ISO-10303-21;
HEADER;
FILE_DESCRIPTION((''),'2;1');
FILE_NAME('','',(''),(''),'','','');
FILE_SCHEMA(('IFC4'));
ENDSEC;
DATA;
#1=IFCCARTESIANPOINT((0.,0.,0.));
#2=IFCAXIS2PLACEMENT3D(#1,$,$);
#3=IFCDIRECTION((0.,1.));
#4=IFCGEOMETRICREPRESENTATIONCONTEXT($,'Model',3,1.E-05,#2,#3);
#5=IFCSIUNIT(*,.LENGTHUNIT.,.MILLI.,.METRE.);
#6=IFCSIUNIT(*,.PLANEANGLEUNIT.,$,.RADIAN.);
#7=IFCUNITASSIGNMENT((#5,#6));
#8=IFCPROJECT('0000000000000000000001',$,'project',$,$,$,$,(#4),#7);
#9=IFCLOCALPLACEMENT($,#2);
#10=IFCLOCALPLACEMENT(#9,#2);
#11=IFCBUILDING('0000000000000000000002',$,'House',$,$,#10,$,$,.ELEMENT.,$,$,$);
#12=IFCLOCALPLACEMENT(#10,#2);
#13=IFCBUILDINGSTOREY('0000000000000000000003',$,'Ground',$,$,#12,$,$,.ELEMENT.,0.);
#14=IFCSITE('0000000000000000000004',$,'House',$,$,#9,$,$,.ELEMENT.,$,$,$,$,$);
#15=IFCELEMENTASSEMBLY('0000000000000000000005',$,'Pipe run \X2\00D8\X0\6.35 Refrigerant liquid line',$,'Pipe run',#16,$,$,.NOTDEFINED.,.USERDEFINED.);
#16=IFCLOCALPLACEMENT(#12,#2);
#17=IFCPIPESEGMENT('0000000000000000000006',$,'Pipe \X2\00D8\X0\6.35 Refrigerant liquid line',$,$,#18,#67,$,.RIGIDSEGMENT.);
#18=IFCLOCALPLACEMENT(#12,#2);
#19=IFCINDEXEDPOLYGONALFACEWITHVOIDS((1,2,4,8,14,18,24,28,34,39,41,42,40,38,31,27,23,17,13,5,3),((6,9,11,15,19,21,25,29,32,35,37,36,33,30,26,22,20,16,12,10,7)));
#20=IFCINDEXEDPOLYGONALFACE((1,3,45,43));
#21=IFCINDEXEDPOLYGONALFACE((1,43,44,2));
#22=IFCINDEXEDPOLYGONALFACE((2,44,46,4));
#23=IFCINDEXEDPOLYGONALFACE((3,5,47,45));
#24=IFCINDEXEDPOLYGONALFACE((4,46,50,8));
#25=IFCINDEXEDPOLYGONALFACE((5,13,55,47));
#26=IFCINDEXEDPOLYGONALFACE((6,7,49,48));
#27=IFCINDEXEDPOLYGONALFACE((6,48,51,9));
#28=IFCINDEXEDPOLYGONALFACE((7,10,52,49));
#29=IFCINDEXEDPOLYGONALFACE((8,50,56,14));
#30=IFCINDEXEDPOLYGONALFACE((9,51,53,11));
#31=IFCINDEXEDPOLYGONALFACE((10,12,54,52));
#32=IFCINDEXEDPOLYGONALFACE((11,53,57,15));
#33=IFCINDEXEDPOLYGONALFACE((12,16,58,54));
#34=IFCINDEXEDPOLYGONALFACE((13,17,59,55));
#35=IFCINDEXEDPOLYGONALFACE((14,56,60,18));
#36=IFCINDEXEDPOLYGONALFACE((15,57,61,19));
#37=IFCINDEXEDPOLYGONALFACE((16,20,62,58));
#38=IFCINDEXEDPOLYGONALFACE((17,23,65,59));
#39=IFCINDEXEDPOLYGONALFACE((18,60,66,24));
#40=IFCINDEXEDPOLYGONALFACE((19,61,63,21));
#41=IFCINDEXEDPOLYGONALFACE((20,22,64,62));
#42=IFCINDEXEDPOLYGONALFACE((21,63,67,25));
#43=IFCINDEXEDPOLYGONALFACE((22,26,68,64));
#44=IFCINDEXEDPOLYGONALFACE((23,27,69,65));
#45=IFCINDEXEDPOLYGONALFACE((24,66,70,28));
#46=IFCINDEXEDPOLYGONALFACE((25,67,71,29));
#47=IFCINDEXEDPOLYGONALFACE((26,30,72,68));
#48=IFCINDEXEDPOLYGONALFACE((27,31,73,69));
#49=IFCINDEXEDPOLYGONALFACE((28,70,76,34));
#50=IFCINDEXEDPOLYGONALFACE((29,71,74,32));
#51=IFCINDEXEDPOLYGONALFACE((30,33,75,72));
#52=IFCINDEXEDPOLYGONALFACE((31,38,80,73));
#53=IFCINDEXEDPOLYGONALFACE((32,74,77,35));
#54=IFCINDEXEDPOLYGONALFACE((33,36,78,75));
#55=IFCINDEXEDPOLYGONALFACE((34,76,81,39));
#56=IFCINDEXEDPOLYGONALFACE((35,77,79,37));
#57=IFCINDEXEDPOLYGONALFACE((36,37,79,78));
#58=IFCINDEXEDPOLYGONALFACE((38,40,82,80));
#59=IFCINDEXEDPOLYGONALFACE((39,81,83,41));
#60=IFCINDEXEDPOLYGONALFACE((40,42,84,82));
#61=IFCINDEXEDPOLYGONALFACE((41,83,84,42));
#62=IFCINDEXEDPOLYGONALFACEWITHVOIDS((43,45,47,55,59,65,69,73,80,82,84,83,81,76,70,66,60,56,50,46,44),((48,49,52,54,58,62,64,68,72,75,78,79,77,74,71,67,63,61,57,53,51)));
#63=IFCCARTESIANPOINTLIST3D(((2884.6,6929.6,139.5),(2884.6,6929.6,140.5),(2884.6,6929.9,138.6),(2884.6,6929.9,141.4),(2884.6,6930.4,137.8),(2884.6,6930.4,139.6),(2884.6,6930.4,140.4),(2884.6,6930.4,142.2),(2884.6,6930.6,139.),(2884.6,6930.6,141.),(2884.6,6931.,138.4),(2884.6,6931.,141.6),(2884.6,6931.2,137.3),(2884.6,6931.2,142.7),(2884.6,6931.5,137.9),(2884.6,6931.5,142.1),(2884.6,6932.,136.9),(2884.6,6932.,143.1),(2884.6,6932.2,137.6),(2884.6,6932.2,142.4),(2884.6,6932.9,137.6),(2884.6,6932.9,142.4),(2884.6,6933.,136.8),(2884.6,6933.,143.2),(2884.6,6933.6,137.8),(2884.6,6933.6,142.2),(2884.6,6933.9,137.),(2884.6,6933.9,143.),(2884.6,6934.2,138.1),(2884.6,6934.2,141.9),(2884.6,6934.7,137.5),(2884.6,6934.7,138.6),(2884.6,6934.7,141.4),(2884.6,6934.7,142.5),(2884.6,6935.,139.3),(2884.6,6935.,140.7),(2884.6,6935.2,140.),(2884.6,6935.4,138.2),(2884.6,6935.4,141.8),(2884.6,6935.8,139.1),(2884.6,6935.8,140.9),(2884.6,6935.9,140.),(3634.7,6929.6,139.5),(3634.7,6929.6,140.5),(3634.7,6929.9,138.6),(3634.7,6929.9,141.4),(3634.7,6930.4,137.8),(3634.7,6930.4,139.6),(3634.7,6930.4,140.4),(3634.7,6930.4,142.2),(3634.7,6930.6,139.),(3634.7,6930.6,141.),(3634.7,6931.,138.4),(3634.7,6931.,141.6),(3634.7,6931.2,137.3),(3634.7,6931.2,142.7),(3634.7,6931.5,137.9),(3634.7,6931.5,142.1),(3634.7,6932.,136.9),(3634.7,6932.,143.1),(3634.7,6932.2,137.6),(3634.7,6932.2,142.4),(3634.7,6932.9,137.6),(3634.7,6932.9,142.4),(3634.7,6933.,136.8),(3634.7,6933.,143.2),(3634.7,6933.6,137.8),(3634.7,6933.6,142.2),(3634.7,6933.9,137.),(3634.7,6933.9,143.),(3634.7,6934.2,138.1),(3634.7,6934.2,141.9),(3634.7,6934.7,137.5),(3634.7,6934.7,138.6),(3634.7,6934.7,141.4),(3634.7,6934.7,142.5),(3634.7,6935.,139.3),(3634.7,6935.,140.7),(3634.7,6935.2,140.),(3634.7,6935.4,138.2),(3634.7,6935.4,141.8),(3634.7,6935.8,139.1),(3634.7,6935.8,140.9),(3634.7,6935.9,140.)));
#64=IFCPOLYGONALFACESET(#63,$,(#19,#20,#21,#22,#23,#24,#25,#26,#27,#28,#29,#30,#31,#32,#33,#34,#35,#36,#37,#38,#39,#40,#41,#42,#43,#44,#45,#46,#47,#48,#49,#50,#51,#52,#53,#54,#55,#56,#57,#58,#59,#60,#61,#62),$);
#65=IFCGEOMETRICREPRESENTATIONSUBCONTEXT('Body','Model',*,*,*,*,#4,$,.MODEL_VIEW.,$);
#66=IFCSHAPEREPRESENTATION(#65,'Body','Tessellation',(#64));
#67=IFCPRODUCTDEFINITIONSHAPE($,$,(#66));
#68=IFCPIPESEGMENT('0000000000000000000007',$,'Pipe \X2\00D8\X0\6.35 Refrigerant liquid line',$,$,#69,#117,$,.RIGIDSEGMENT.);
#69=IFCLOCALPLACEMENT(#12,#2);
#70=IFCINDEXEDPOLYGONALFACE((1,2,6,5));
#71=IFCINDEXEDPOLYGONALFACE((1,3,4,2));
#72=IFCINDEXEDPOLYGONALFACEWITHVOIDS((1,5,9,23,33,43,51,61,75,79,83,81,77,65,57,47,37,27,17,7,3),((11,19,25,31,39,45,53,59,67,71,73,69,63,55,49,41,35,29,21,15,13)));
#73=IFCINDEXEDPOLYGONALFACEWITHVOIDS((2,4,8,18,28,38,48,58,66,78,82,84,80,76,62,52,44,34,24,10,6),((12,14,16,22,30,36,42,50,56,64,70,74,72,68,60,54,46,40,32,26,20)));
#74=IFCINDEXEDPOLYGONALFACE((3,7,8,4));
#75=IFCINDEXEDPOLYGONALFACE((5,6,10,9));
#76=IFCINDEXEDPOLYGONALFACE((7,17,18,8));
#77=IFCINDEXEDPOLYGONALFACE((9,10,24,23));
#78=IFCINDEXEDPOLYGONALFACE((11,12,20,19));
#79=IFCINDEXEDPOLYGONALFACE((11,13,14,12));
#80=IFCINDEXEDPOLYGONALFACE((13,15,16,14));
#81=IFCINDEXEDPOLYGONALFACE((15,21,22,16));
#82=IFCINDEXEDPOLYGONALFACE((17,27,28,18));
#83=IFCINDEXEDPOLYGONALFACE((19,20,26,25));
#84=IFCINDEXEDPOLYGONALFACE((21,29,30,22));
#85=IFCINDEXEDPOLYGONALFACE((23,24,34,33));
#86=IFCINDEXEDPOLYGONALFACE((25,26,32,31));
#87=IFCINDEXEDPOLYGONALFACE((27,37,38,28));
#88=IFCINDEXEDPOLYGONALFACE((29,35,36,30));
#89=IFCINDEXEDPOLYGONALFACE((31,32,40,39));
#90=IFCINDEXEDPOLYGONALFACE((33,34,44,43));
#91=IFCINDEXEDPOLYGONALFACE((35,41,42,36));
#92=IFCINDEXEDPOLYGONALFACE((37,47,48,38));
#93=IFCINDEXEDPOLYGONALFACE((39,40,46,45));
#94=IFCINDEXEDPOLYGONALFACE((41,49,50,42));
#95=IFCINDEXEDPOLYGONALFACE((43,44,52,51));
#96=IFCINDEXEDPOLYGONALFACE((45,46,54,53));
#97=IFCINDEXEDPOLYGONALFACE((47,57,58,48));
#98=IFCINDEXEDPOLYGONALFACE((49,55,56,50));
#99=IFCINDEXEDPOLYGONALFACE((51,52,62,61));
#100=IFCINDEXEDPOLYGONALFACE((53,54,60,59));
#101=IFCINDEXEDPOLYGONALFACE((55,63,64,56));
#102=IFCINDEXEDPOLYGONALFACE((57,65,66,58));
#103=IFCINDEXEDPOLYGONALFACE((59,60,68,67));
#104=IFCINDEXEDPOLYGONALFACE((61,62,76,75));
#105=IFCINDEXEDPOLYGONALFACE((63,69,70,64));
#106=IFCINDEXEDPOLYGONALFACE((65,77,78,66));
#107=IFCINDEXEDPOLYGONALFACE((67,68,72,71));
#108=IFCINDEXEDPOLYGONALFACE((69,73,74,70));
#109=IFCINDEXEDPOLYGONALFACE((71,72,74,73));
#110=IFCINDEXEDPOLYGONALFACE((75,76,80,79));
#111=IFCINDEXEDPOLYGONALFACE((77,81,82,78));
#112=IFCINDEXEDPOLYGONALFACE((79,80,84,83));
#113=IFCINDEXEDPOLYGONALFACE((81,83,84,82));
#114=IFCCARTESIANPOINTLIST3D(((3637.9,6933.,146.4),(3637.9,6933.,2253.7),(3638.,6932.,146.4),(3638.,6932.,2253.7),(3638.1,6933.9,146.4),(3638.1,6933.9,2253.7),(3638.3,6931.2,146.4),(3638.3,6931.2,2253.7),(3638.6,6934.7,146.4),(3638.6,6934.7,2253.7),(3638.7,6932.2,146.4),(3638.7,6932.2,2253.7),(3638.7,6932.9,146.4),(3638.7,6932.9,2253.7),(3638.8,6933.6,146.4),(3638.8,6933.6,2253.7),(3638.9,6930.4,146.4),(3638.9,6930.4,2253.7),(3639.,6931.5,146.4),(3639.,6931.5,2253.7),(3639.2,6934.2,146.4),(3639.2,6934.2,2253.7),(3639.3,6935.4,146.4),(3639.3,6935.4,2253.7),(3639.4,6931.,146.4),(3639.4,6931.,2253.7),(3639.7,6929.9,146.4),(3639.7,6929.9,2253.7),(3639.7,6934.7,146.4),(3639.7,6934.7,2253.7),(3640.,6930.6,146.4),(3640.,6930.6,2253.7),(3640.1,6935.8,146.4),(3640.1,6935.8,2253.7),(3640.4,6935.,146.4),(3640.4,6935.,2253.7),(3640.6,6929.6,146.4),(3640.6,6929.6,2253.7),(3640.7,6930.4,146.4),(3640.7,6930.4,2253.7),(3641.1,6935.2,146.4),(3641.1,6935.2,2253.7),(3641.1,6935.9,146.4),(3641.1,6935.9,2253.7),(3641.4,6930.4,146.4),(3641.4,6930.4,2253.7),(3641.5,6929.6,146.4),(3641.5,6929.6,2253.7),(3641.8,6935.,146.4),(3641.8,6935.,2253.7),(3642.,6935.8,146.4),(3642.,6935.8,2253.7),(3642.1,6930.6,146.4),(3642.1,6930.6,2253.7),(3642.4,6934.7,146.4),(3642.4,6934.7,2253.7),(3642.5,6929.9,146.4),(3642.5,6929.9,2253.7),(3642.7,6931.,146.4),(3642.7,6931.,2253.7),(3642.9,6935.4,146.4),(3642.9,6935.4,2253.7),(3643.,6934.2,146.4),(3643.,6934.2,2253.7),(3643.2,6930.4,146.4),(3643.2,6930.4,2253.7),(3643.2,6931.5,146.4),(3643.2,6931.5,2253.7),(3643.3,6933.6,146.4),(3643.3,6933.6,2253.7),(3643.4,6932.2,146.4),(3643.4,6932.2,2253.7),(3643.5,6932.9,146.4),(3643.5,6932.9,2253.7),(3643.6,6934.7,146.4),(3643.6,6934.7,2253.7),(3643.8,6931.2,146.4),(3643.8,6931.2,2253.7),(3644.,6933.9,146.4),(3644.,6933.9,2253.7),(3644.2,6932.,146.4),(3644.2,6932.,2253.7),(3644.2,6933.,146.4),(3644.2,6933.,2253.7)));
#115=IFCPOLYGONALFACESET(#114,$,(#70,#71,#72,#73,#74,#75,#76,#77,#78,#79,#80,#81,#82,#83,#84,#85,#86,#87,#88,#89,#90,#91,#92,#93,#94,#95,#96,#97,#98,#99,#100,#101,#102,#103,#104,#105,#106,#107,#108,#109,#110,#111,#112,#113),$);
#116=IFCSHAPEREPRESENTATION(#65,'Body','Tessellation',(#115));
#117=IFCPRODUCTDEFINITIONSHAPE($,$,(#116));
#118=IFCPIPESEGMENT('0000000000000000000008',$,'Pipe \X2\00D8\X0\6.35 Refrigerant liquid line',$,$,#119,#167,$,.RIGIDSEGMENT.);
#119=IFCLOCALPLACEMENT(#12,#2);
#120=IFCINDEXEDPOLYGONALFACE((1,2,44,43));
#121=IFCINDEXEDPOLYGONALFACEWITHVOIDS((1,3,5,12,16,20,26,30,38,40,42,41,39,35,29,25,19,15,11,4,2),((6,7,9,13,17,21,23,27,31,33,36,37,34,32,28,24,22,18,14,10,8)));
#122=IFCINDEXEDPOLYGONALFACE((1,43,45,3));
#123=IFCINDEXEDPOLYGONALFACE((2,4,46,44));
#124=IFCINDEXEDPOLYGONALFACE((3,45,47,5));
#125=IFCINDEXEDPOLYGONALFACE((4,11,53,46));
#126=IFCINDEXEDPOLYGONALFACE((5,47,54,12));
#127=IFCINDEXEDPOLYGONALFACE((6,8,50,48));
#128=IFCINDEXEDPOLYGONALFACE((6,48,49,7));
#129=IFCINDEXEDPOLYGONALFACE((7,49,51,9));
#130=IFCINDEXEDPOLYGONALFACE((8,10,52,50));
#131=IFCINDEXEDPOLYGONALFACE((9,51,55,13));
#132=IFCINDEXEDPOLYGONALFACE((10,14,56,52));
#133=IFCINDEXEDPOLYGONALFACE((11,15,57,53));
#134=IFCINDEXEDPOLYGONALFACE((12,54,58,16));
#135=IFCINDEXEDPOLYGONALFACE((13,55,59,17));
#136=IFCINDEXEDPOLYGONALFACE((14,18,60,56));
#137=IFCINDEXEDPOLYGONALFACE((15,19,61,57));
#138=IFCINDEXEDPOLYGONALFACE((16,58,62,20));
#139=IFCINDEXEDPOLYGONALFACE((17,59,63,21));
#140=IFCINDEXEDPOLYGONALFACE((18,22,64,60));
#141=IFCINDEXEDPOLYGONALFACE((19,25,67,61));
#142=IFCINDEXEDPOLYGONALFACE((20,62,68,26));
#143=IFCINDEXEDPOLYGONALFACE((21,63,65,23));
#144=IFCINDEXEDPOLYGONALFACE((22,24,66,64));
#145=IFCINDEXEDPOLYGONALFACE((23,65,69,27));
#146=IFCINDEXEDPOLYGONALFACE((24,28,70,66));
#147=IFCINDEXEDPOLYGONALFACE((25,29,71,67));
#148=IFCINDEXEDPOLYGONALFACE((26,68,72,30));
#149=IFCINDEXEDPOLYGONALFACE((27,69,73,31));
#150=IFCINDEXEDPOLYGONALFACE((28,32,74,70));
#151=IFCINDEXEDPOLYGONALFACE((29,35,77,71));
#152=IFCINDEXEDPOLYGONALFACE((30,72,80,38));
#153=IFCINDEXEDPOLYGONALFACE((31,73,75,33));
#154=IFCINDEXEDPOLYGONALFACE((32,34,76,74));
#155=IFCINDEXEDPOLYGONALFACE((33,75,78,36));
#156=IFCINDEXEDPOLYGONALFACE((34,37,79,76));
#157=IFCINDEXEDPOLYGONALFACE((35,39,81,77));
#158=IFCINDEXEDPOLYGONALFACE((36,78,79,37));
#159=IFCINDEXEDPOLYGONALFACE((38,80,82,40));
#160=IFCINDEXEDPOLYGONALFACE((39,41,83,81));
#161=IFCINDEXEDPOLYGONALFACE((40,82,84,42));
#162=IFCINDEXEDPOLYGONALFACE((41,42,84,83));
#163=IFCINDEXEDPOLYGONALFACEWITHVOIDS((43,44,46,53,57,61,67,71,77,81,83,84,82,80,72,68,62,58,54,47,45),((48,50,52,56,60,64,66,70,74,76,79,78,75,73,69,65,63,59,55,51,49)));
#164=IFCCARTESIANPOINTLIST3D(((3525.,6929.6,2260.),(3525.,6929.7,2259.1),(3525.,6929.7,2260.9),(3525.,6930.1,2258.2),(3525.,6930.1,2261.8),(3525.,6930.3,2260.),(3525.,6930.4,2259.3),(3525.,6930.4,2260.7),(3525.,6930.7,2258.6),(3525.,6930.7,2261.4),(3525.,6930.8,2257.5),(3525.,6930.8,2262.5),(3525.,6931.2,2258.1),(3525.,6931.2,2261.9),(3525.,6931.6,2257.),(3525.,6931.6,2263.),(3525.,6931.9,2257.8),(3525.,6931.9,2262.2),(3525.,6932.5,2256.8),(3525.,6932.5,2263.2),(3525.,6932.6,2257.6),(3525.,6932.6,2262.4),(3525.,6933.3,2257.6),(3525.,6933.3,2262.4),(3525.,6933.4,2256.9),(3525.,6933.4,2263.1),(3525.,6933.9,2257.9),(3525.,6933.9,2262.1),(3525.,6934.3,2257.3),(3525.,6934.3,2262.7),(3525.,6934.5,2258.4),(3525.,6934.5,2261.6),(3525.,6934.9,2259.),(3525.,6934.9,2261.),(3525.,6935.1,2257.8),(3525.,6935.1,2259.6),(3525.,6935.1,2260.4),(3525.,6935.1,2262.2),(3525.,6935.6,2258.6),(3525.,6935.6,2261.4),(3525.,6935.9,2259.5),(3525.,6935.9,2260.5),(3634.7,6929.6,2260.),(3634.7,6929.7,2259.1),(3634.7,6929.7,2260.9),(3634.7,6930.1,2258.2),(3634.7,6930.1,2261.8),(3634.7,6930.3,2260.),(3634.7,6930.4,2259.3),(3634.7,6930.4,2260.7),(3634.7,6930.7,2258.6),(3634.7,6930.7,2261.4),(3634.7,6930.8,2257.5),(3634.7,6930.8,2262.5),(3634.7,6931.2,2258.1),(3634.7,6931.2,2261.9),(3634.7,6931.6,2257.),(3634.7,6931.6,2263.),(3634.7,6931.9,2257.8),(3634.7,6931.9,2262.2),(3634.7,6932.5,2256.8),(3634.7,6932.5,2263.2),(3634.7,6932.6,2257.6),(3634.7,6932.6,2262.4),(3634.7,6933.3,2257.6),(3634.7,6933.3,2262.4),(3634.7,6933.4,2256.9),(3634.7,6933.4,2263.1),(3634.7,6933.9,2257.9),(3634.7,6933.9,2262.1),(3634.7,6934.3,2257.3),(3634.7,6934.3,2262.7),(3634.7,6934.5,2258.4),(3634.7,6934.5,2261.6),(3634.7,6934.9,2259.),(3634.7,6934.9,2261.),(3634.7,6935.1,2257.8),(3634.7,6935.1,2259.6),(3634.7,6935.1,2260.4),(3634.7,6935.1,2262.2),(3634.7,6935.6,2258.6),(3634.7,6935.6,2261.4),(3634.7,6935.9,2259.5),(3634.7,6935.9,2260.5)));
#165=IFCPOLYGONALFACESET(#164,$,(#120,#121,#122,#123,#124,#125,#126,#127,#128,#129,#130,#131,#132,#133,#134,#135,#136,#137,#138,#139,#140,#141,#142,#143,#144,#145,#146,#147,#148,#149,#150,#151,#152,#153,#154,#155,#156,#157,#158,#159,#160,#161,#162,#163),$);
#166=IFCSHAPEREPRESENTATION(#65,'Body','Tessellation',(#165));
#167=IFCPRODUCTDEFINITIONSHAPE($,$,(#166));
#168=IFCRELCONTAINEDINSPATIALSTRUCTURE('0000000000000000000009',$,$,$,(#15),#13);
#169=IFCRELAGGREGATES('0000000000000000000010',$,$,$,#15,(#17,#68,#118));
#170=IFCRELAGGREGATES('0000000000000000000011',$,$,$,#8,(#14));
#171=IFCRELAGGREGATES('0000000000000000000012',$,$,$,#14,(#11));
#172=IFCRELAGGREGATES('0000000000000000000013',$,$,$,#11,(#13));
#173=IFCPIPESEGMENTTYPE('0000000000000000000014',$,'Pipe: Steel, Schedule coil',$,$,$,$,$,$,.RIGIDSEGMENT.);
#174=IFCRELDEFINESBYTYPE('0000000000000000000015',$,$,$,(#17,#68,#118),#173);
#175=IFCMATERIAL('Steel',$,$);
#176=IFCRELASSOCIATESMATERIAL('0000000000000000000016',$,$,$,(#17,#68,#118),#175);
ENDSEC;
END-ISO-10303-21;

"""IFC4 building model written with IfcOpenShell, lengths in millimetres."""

from ifc_helpers import new_model, si_unit, direction, frame, origin, origin_with_axes, origin_2d, place, context, subcontext, project, spatial, hollow_circle, extrude, material, type_object, element, aggregate, save


model = new_model("IFC4")

# Units and contexts
model_context = context("Model", 3, precision=1e-05, world=origin(), true_north=direction((0.0, 1.0)))
body_context = subcontext(model_context, "Body", "Model", "MODEL_VIEW")
ifc_project = project(units=[si_unit("LENGTHUNIT", "METRE", prefix="MILLI"), si_unit("PLANEANGLEUNIT", "RADIAN")], contexts=[model_context])

# Site, building, storey
site_placement = place(None, origin())
site = spatial("IfcSite", under=ifc_project, at=site_placement, Name="House", CompositionType="ELEMENT")
building_placement = place(site_placement, origin())
building = spatial("IfcBuilding", under=site, at=building_placement, Name="House", CompositionType="ELEMENT")
storey_placement = place(building_placement, origin())
storey = spatial("IfcBuildingStorey", under=building, at=storey_placement, Name="Ground", CompositionType="ELEMENT", Elevation=0.0)

# Element assembly, pipe segments
ifc_material = material(Name="Steel")
pipe_segment_type = type_object("IfcPipeSegmentType", Name="Pipe: Steel, Schedule coil", PredefinedType="RIGIDSEGMENT")
assembly_1_placement = place(storey_placement, origin_with_axes())
assembly_1 = element("IfcElementAssembly", 1, at=assembly_1_placement, inside=storey, Name="Pipe run Ø6.35 Refrigerant liquid line", ObjectType="Pipe run", AssemblyPlace="NOTDEFINED", PredefinedType="USERDEFINED")
pipe_segment_1_placement = place(storey_placement, origin_with_axes())
pipe_segment_1 = element("IfcPipeSegment", 2, at=pipe_segment_1_placement, type_object=pipe_segment_type, material=ifc_material, Name="Pipe Ø6.35 Refrigerant liquid line", PredefinedType="RIGIDSEGMENT", context=body_context, shape_type="SweptSolid", body=[
    extrude(hollow_circle(Radius=3.2, WallThickness=0.8, at=origin_2d()), frame((2884.6, 6932.7, 140.0), z_axis=(1.0, 0.0, 0.0), x_axis=(0.0, 1.0, 0.0)), (0.0, 0.0, 1.0), 750.1),
])
pipe_segment_2_placement = place(storey_placement, origin_with_axes())
pipe_segment_2 = element("IfcPipeSegment", 3, at=pipe_segment_2_placement, type_object=pipe_segment_type, material=ifc_material, Name="Pipe Ø6.35 Refrigerant liquid line", PredefinedType="RIGIDSEGMENT", context=body_context, shape_type="SweptSolid", body=[
    extrude(hollow_circle(Radius=3.2, WallThickness=0.8, at=origin_2d()), frame((3641.1, 6932.7, 146.3), z_axis=(0.0, 0.0, 1.0), x_axis=(0.0, 1.0, 0.0)), (0.0, 0.0, 1.0), 2107.3),
])
pipe_segment_3_placement = place(storey_placement, origin_with_axes())
pipe_segment_3 = element("IfcPipeSegment", 4, at=pipe_segment_3_placement, type_object=pipe_segment_type, material=ifc_material, Name="Pipe Ø6.35 Refrigerant liquid line", PredefinedType="RIGIDSEGMENT", context=body_context, shape_type="SweptSolid", body=[
    extrude(hollow_circle(Radius=3.2, WallThickness=0.8, at=origin_2d()), frame((3634.7, 6932.7, 2260.0), z_axis=(-1.0, 0.0, 0.0), x_axis=(0.0, -1.0, 0.0)), (0.0, 0.0, 1.0), 109.7),
])

aggregate(assembly_1, [pipe_segment_1, pipe_segment_2, pipe_segment_3])

save(model, "model.ifc")
